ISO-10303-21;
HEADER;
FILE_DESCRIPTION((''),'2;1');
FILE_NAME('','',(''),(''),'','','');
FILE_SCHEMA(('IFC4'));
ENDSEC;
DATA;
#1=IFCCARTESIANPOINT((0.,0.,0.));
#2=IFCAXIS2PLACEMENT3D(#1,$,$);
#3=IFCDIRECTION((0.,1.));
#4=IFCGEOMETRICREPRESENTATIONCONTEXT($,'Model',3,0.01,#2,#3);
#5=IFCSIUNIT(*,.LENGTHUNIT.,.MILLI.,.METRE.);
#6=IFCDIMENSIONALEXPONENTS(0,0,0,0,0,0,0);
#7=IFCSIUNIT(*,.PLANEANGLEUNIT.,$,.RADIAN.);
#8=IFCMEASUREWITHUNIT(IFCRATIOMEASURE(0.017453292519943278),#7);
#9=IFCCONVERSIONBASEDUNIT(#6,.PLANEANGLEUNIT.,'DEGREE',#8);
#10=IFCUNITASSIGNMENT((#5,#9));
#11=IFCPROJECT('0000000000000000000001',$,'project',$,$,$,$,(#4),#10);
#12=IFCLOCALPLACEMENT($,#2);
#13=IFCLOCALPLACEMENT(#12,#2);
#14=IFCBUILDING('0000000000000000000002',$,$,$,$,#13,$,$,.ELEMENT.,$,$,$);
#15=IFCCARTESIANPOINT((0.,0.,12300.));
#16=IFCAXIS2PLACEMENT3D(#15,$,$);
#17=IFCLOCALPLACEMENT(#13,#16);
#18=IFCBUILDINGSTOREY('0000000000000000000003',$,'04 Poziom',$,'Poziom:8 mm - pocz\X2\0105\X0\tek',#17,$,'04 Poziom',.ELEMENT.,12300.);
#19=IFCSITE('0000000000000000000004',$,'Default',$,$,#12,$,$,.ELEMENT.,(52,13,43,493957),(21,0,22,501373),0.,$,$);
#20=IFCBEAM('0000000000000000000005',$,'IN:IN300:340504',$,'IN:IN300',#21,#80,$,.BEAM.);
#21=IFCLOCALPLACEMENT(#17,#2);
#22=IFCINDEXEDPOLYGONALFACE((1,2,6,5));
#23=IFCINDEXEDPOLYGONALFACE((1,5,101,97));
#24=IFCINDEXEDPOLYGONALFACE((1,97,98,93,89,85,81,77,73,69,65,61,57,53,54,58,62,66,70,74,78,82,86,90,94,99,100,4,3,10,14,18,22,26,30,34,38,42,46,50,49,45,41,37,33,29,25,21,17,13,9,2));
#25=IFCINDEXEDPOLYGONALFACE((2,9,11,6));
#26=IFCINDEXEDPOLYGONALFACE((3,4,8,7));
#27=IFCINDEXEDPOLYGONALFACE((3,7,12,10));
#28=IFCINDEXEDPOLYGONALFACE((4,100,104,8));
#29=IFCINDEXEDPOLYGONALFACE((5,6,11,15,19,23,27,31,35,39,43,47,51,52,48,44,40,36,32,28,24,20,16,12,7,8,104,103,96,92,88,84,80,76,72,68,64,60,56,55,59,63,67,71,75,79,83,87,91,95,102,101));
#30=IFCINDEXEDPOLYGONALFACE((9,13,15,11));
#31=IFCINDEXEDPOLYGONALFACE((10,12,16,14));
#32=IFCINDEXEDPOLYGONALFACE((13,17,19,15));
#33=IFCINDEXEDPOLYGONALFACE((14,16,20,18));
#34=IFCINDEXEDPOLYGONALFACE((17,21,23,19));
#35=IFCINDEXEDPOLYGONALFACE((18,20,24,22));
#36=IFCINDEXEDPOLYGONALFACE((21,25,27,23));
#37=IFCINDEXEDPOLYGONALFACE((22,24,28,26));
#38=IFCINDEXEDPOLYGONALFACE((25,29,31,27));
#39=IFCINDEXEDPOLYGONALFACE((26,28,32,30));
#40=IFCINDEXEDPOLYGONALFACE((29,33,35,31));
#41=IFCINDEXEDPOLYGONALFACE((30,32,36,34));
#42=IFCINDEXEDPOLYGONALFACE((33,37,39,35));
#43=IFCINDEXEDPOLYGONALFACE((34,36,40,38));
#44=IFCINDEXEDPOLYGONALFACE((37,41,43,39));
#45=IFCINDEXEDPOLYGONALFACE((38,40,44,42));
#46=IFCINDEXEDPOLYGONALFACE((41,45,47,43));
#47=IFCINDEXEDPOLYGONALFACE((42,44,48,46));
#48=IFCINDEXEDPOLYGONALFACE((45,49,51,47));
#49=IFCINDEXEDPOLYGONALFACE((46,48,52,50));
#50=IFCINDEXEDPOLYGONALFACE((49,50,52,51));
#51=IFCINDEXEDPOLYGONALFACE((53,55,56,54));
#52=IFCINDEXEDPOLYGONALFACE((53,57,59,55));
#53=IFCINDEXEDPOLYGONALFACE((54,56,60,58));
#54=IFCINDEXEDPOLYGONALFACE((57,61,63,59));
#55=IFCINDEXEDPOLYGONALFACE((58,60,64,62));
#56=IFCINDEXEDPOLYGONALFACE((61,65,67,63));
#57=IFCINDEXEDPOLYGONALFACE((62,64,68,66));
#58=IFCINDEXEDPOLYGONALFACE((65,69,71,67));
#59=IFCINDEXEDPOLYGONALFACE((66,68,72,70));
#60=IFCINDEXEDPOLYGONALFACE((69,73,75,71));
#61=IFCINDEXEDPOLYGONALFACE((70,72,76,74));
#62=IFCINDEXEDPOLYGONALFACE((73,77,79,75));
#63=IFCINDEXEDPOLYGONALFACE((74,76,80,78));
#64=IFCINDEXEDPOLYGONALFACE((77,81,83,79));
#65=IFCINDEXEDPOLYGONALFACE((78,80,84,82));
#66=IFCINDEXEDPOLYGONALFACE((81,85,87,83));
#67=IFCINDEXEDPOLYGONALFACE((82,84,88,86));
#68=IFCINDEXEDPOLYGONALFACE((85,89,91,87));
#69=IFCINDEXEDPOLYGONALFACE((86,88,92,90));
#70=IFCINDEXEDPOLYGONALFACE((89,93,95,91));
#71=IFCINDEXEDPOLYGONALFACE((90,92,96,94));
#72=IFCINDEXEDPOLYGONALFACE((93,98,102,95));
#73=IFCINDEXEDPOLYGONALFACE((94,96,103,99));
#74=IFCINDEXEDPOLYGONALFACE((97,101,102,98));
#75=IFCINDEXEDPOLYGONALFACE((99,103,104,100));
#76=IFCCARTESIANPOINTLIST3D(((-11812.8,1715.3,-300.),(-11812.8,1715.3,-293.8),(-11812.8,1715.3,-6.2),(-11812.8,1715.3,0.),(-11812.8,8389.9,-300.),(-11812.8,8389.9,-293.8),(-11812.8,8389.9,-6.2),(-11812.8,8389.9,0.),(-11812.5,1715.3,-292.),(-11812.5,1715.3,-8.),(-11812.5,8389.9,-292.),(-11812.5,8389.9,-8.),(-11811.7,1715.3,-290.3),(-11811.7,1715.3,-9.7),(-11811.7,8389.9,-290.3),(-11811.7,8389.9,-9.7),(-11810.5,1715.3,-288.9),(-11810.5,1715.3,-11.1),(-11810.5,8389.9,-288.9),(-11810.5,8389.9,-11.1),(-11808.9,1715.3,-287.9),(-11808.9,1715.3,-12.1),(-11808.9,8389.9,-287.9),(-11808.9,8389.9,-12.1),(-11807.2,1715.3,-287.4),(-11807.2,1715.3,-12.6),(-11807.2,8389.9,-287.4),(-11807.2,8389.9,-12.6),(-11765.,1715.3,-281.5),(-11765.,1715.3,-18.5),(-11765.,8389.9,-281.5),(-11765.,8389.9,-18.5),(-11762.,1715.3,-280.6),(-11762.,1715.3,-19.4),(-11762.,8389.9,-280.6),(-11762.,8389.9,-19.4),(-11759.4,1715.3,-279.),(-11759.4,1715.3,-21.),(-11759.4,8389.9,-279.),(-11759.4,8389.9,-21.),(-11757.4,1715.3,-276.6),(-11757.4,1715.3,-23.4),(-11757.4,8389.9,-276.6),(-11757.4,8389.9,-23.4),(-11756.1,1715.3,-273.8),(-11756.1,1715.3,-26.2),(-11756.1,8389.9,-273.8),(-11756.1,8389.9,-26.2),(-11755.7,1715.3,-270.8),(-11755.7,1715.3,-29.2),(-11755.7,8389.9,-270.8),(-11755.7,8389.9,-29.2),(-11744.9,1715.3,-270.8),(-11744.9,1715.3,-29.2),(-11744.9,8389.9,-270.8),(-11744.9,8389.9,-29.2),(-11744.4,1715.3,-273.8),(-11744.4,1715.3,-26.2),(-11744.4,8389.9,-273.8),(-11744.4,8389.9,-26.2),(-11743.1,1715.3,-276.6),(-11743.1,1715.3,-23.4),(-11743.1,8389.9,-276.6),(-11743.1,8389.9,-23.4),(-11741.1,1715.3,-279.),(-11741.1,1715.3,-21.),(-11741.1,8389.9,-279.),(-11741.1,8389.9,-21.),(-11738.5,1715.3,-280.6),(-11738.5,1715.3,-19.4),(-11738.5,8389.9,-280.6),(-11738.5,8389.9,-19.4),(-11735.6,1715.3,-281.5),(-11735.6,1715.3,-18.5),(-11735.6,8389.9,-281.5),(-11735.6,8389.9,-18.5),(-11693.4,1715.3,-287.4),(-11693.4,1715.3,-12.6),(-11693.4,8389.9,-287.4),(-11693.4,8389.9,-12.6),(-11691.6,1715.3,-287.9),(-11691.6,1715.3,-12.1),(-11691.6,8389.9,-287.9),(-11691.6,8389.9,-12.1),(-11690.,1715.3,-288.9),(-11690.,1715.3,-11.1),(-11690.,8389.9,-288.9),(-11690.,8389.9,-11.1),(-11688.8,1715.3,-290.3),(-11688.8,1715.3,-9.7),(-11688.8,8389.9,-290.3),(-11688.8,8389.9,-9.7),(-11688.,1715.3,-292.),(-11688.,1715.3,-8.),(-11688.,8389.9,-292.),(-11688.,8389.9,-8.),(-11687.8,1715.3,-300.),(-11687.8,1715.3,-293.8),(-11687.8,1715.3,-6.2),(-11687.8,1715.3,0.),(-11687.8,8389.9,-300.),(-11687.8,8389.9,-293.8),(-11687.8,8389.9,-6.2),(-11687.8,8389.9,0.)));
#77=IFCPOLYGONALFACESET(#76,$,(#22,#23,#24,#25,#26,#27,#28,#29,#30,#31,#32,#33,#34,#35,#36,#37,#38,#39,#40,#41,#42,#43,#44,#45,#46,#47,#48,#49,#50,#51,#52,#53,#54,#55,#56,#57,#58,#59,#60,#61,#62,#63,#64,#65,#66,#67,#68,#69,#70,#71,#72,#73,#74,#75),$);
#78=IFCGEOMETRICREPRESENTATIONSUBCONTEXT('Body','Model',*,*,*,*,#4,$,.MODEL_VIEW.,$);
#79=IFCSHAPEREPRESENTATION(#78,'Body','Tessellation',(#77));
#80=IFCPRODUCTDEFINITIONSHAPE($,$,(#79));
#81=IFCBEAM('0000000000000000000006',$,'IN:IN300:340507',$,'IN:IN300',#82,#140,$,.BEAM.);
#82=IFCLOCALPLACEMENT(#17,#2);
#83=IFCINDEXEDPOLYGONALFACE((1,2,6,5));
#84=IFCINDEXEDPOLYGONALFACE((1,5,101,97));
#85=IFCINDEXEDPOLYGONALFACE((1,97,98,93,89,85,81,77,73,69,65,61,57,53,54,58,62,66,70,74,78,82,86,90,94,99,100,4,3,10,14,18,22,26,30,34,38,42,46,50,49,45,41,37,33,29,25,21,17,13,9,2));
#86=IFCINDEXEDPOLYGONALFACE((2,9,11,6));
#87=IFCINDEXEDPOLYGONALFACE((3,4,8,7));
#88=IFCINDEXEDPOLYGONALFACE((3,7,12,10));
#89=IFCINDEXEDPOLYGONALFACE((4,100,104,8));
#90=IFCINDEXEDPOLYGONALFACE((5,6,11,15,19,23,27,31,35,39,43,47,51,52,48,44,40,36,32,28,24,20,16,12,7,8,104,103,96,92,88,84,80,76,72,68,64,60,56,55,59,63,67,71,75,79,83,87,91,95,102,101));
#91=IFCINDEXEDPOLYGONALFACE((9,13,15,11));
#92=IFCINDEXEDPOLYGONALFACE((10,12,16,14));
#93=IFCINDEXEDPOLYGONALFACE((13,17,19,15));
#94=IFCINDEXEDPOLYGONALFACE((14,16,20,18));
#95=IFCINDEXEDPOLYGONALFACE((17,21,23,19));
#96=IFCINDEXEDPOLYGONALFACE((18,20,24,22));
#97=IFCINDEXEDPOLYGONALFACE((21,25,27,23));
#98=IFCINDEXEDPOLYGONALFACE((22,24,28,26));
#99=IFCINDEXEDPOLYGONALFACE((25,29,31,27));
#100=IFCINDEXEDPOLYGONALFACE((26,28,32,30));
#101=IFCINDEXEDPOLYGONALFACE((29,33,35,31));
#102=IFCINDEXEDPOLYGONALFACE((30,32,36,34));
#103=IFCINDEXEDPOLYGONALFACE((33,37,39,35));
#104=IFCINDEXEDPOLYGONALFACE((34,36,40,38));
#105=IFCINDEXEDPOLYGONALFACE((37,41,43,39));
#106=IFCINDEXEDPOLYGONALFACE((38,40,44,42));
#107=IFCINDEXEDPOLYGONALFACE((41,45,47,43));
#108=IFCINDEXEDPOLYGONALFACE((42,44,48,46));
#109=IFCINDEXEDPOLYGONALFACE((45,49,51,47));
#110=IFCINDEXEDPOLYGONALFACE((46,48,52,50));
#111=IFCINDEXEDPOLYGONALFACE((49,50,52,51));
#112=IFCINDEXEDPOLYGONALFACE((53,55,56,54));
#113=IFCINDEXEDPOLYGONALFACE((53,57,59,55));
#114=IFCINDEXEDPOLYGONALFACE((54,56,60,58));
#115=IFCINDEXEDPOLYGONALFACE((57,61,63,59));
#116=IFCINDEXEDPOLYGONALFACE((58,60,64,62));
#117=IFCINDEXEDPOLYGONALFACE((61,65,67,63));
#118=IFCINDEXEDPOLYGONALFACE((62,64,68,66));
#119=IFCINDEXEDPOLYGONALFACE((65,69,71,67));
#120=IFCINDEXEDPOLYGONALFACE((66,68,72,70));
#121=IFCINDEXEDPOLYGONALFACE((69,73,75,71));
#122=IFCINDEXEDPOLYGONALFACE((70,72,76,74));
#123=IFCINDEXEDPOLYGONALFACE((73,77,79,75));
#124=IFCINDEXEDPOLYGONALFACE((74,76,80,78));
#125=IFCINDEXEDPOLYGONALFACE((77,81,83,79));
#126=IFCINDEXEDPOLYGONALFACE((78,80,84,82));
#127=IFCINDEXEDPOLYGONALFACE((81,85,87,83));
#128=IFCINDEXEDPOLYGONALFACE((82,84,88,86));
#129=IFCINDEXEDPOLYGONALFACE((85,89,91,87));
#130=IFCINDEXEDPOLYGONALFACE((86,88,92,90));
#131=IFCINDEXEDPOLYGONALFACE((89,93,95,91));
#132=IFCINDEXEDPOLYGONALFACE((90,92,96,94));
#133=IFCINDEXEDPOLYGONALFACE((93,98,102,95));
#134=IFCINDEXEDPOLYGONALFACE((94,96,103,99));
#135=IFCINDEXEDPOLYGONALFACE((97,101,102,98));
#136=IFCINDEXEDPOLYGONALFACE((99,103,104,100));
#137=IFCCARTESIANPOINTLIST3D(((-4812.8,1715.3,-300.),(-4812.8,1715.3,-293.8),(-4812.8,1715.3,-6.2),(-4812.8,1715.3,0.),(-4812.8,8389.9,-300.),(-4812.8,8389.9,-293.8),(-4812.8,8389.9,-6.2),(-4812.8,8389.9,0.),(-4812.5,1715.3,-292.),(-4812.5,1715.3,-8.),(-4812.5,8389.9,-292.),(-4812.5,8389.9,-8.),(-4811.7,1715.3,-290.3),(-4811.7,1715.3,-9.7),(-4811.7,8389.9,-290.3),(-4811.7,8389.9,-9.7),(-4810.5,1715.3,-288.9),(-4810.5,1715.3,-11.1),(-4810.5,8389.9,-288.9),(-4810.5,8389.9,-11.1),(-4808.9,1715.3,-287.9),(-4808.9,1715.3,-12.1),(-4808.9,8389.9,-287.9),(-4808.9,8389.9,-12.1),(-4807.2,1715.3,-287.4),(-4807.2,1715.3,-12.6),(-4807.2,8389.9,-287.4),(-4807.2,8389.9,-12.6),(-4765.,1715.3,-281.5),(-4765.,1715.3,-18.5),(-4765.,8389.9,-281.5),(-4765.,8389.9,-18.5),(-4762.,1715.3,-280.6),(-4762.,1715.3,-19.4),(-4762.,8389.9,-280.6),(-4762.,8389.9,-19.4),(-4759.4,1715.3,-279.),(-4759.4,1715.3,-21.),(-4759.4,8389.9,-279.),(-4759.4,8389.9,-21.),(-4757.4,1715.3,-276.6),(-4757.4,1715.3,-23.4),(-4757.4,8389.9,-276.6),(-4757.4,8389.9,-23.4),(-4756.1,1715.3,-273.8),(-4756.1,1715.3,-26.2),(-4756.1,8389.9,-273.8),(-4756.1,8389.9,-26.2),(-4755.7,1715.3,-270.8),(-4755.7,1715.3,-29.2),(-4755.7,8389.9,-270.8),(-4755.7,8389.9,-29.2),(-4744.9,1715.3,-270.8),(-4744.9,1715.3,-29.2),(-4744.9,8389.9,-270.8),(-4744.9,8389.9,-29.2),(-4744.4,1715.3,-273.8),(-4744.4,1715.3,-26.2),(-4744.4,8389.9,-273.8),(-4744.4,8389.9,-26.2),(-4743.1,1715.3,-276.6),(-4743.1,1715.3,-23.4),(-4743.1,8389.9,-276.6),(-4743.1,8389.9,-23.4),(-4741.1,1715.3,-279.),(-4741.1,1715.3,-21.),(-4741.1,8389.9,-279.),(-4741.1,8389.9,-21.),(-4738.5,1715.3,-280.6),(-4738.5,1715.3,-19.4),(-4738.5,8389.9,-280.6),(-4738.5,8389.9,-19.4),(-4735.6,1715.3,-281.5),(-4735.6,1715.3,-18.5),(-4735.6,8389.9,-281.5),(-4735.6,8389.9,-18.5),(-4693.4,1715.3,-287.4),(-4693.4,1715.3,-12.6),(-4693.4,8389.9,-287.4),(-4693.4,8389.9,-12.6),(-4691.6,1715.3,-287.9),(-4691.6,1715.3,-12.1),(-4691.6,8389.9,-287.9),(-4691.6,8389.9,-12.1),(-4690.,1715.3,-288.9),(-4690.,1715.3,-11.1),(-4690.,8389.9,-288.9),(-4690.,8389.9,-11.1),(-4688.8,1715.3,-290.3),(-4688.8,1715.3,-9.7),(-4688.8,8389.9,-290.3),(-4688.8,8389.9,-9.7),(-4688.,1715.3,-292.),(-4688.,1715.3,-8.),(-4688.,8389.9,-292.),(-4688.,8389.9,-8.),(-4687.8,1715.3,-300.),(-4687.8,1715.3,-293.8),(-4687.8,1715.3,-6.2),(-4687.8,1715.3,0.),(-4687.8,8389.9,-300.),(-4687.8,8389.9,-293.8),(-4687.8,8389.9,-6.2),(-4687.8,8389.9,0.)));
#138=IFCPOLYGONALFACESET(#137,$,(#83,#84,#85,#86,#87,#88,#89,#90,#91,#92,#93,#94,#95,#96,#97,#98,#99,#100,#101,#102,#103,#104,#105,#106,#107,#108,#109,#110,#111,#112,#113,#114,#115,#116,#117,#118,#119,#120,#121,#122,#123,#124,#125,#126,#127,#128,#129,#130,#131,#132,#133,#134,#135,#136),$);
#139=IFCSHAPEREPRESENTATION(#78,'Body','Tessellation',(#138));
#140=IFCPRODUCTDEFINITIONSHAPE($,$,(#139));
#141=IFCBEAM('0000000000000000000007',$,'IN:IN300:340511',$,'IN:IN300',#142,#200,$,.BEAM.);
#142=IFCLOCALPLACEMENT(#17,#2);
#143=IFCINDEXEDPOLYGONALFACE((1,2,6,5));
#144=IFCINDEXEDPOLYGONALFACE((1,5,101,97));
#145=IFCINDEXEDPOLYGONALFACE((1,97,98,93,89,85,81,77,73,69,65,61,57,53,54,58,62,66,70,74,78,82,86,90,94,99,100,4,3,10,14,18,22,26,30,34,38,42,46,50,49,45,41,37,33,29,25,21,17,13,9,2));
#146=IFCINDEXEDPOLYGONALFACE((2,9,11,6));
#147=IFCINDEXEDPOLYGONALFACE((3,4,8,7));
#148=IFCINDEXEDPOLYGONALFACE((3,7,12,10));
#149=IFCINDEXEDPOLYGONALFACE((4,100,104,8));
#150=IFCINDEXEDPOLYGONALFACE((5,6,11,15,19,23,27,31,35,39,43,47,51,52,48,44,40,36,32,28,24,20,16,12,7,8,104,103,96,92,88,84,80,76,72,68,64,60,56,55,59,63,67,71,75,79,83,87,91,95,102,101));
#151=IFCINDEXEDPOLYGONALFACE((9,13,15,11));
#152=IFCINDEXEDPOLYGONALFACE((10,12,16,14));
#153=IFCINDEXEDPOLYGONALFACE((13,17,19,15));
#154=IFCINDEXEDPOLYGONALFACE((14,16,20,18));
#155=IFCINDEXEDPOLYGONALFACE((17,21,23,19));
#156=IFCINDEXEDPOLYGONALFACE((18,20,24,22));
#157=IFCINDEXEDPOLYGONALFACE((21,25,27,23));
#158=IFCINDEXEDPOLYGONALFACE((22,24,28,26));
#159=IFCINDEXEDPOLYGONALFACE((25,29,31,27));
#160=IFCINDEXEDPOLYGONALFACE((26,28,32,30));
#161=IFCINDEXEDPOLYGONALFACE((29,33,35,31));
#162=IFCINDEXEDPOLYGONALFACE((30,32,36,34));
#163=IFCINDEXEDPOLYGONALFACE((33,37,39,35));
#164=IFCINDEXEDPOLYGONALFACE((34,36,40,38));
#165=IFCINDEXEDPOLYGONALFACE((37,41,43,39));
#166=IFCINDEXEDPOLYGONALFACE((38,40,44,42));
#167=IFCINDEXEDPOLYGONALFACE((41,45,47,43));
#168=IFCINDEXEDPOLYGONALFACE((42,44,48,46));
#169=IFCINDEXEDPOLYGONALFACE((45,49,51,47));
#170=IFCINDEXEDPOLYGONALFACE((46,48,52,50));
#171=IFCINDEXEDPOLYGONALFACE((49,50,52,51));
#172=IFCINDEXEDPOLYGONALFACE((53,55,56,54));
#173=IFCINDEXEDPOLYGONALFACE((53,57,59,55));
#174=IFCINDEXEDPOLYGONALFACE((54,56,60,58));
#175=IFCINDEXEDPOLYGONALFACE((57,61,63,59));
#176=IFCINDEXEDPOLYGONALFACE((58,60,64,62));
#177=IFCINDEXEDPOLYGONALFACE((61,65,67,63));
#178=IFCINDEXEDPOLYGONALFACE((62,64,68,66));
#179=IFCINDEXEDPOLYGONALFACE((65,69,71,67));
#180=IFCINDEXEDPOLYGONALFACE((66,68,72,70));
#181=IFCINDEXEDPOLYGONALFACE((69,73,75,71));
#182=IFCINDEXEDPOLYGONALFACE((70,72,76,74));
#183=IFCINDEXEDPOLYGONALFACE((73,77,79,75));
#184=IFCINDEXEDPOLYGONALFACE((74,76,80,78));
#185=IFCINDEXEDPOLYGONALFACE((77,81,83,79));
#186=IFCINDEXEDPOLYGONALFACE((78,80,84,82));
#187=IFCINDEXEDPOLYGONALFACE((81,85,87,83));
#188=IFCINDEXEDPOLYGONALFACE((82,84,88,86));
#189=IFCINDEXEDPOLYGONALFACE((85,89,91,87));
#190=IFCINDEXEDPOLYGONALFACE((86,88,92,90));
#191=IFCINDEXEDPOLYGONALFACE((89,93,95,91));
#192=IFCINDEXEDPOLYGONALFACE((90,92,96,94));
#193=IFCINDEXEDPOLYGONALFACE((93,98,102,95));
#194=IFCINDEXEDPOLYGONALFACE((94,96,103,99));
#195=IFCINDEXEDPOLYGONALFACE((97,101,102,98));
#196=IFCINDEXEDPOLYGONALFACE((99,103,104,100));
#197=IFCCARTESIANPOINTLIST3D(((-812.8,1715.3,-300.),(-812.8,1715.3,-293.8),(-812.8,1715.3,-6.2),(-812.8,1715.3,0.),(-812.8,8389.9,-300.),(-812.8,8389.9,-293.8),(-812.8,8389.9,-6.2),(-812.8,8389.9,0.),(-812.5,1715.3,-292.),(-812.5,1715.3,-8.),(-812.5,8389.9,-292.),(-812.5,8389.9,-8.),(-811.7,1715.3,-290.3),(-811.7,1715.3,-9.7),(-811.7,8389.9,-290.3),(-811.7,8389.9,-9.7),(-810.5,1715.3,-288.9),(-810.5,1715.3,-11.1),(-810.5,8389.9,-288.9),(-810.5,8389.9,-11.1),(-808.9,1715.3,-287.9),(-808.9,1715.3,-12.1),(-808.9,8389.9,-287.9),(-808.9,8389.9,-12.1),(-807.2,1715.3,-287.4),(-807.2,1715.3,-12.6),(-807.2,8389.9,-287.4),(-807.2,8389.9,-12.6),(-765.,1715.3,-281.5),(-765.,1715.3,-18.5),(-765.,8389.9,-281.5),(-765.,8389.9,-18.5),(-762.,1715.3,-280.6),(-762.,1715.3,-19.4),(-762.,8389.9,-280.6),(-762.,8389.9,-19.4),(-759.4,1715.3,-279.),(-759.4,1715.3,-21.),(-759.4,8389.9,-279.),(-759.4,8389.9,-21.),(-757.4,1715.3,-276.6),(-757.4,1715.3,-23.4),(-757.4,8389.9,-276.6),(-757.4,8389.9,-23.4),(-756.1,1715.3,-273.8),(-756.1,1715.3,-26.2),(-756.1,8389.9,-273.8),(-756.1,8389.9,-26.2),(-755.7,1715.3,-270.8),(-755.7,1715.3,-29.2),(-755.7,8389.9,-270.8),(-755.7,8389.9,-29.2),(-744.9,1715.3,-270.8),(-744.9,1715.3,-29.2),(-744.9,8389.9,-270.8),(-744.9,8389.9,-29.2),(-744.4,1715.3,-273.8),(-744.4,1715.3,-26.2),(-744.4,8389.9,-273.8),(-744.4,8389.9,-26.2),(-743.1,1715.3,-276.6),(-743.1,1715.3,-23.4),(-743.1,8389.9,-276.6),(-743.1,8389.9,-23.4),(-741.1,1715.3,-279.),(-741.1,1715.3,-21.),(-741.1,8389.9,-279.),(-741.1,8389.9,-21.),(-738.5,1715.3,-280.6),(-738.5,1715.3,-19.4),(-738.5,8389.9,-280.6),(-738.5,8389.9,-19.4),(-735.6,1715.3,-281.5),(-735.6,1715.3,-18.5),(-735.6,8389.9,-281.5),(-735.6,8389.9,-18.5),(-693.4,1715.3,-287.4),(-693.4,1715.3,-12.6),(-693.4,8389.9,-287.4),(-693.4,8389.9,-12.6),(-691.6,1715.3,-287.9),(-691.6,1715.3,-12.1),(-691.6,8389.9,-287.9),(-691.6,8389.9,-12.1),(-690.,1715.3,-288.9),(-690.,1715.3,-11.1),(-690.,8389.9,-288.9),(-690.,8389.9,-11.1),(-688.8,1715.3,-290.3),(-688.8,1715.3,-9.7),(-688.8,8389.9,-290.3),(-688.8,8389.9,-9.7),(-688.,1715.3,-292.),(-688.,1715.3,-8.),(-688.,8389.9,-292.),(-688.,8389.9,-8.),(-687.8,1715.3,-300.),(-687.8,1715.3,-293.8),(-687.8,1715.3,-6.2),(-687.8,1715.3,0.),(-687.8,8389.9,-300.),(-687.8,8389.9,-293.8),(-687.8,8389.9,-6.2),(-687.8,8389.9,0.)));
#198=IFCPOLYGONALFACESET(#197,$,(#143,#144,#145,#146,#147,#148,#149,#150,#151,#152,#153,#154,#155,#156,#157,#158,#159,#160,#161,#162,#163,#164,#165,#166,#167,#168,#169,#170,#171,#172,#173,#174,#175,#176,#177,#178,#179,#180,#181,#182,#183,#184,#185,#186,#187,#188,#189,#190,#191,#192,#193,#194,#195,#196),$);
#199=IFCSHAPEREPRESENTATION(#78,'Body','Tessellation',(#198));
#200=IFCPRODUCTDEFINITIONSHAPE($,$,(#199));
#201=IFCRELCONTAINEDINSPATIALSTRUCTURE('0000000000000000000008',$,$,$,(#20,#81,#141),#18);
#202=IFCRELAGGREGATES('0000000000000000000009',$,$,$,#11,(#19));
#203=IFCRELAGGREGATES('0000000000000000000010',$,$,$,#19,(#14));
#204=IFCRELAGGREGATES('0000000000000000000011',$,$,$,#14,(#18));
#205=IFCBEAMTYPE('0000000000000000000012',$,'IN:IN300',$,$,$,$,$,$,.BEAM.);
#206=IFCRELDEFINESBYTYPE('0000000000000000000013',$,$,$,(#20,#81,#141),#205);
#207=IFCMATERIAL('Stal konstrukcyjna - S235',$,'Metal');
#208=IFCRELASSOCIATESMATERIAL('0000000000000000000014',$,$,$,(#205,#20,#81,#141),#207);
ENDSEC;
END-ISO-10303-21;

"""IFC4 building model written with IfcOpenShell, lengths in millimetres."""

from ifc_helpers import new_model, entity, si_unit, converted_unit, direction, frame, origin, place, context, subcontext, project, spatial, line, arc, indexed_curve, outline, extrude, source, transform, mapped, material, type_object, type_shapes, element, save


model = new_model("IFC4")

# Units and contexts
model_context = context("Model", 3, precision=0.01, world=origin(), true_north=direction((0.0, 1.0)))
body_context = subcontext(model_context, "Body", "Model", "MODEL_VIEW")
ifc_project = project(units=[si_unit("LENGTHUNIT", "METRE", prefix="MILLI"), converted_unit("PLANEANGLEUNIT", "DEGREE", entity("IfcRatioMeasure", 0.017453292519943278), si_unit("PLANEANGLEUNIT", "RADIAN"), dimensions=[0, 0, 0, 0, 0, 0, 0])], contexts=[model_context])

# Site, building, storey
site_placement = place(None, origin())
site = spatial("IfcSite", under=ifc_project, at=site_placement, Name="Default", CompositionType="ELEMENT", RefLatitude=(52, 13, 43, 493957), RefLongitude=(21, 0, 22, 501373), RefElevation=0.0)
building_placement = place(site_placement, origin())
building = spatial("IfcBuilding", under=site, at=building_placement, CompositionType="ELEMENT")
storey_placement = place(building_placement, frame((0.0, 0.0, 12300.0)))
storey = spatial("IfcBuildingStorey", under=building, at=storey_placement, Name="04 Poziom", ObjectType="Poziom:8 mm - początek", LongName="04 Poziom", CompositionType="ELEMENT", Elevation=12300.0)

# Shared definitions
ifc_material_1 = material(Name="Stal konstrukcyjna - S235", Category="Metal")

# Beams
beam_type_1 = type_object("IfcBeamType", Name="IN:IN300", PredefinedType="BEAM", material=ifc_material_1)
shared_shape_1 = source(origin(), body_context, "Body", "SweptSolid", [
    extrude(outline(indexed_curve([(143.8, -62.5), (150.0, -62.5), (150.0, 62.5), (143.8, 62.5), (139.6, 60.9), (137.4, 56.9), (131.5, 14.7), (127.9, 8.1), (120.8, 5.4), (-120.8, 5.4), (-127.9, 8.1), (-131.5, 14.7), (-137.4, 56.9), (-139.6, 60.9), (-143.8, 62.5), (-150.0, 62.5), (-150.0, -62.5), (-143.8, -62.5), (-139.6, -60.9), (-137.4, -56.9), (-131.5, -14.7), (-127.9, -8.1), (-120.8, -5.4), (120.8, -5.4), (127.9, -8.1), (131.5, -14.7), (137.4, -56.9), (139.6, -60.9)], segments=[line(1, 2, 3, 4), arc(4, 5, 6), line(6, 7), arc(7, 8, 9), line(9, 10), arc(10, 11, 12), line(12, 13), arc(13, 14, 15), line(15, 16, 17, 18), arc(18, 19, 20), line(20, 21), arc(21, 22, 23), line(23, 24), arc(24, 25, 26), line(26, 27), arc(27, 28, 1)], self_intersect=False)), frame((-3337.3, 0.0, 0.0), z_axis=(1.0, 0.0, 0.0), x_axis=(0.0, 0.0, -1.0)), (0.0, 0.0, 1.0), 6674.6),
])
type_shapes(beam_type_1, [shared_shape_1])
for number, where, z_axis, x_axis, name in (
    (1, (-11750.3, 5052.6, -150.0), (0.0, 0.0, 1.0), (0.0, -1.0, 0.0), "IN:IN300:340504"),
    (2, (-4750.3, 5052.6, -150.0), (0.0, 0.0, 1.0), (0.0, -1.0, 0.0), "IN:IN300:340507"),
    (3, (-750.3, 5052.6, -150.0), (0.0, 0.0, 1.0), (0.0, -1.0, 0.0), "IN:IN300:340511"),
):
    element("IfcBeam", number, at=place(storey_placement, frame(where, z_axis=z_axis, x_axis=x_axis)), inside=storey, type_object=beam_type_1, material=ifc_material_1, Name=name, ObjectType="IN:IN300", PredefinedType="BEAM", context=body_context, shape_type="MappedRepresentation", body=[
        mapped(shared_shape_1, transform((0.0, 0.0, 0.0), scale=1.0)),
    ])

save(model, "model.ifc")
